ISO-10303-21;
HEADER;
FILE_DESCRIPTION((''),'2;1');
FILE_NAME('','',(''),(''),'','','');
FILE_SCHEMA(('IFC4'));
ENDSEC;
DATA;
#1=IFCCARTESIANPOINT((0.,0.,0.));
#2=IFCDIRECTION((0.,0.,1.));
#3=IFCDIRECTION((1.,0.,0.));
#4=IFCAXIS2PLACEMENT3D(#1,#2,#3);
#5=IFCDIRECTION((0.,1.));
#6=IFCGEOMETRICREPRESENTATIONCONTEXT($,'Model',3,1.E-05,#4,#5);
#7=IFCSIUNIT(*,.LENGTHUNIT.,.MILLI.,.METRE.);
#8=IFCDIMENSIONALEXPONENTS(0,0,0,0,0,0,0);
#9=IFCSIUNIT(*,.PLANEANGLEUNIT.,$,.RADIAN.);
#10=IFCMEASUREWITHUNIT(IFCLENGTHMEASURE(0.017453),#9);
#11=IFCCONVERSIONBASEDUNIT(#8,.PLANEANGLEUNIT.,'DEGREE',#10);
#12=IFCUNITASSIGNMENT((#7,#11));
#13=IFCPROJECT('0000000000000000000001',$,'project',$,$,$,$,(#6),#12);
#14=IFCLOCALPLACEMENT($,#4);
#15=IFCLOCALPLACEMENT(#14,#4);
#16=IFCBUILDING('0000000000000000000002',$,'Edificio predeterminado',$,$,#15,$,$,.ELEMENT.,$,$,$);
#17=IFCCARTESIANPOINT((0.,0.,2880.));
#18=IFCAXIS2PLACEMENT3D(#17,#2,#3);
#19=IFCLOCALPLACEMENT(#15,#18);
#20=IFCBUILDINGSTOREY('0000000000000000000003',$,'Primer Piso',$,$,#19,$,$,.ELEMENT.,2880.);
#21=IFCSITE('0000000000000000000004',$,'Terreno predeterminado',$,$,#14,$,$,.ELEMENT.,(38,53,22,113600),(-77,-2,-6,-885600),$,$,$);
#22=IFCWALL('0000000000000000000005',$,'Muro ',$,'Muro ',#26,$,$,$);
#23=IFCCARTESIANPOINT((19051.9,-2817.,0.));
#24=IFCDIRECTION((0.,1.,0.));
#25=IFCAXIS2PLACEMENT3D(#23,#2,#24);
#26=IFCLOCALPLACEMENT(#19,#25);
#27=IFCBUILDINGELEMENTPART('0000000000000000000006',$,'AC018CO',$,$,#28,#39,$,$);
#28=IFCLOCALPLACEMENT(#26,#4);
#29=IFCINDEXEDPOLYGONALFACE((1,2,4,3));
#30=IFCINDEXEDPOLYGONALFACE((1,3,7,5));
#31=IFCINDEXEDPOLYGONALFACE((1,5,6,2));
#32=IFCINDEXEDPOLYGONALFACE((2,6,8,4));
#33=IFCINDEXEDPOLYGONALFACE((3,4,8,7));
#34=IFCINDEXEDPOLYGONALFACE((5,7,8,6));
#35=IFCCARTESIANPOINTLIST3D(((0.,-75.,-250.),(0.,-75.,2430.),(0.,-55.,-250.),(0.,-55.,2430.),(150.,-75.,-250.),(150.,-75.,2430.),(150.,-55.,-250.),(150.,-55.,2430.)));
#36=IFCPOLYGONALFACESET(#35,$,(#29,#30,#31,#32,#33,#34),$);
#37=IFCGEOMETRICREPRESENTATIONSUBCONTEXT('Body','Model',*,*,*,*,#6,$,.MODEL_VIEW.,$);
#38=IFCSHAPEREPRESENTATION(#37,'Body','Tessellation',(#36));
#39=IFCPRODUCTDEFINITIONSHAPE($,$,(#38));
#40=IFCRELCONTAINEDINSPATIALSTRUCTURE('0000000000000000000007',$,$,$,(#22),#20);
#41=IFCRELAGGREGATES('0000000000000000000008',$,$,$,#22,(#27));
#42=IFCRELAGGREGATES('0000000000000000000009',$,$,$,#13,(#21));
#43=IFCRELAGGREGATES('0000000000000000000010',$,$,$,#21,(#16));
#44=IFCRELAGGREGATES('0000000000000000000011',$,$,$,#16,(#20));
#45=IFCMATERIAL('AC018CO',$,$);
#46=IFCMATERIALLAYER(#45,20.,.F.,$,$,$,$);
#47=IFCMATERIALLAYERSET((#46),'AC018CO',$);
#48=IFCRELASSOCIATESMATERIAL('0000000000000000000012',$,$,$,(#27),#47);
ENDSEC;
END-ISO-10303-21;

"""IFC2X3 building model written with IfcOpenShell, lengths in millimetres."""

from ifc_helpers import new_model, entity, si_unit, converted_unit, direction, frame, origin_with_axes, place, context, subcontext, project, spatial, polyline, outline, extrude, clip, bounded_halfspace, material, layer, layer_set, layer_usage, element, aggregate, save


model = new_model("IFC2X3")

# Units and contexts
model_context = context("Model", 3, precision=1e-05, world=origin_with_axes(), true_north=direction((0.0, 1.0)))
body_context = subcontext(model_context, "Body", "Model", "MODEL_VIEW")
ifc_project = project(units=[si_unit("LENGTHUNIT", "METRE", prefix="MILLI"), converted_unit("PLANEANGLEUNIT", "DEGREE", entity("IfcLengthMeasure", 0.017453), si_unit("PLANEANGLEUNIT", "RADIAN"), dimensions=[0, 0, 0, 0, 0, 0, 0])], contexts=[model_context])

# Site, building, storey
site_placement = place(None, origin_with_axes())
site = spatial("IfcSite", under=ifc_project, at=site_placement, Name="Terreno predeterminado", CompositionType="ELEMENT", RefLatitude=(38, 53, 22, 113600), RefLongitude=(-77, -2, -6, -885600))
building_placement = place(site_placement, origin_with_axes())
building = spatial("IfcBuilding", under=site, at=building_placement, Name="Edificio predeterminado", CompositionType="ELEMENT")
storey_placement = place(building_placement, frame((0.0, 0.0, 2880.0), z_axis=(0.0, 0.0, 1.0), x_axis=(1.0, 0.0, 0.0)))
storey = spatial("IfcBuildingStorey", under=building, at=storey_placement, Name="Primer Piso", CompositionType="ELEMENT", Elevation=2880.0)

# Wall, building element part
wall_1_placement = place(storey_placement, frame((19051.9, -2817.0, 0.0), z_axis=(0.0, 0.0, 1.0), x_axis=(0.0, 1.0, 0.0)))
wall_1 = element("IfcWall", 1, at=wall_1_placement, inside=storey, Name="Muro ", ObjectType="Muro ")
ifc_material_1 = material(Name="AC018CO")
ifc_layer_1 = layer(ifc_material_1, 20.0, ventilated=False)
ifc_layer_set_1 = layer_set([ifc_layer_1], Name="AC018CO")
ifc_layer_usage_1 = layer_usage(ifc_layer_set_1, "AXIS2", "NEGATIVE", 55.0)
building_element_part_1_placement = place(wall_1_placement, origin_with_axes())
building_element_part_1 = element("IfcBuildingElementPart", 2, at=building_element_part_1_placement, material=ifc_layer_usage_1, Name="AC018CO", context=body_context, shape_type="Clipping", body=[
    clip(clip(extrude(outline(polyline([(150.0, -55.0), (150.0, -75.0), (0.0, -75.0), (0.0, -55.0), (150.0, -55.0)])), frame((0.0, 0.0, -250.0), z_axis=(0.0, 0.0, 1.0), x_axis=(1.0, 0.0, 0.0)), (0.0, 0.0, 1.0), 2680.0), bounded_halfspace(frame((0.0, 0.0, -250.0), z_axis=(0.0, 0.0, 1.0), x_axis=(1.0, 0.0, 0.0)), True, origin_with_axes(), polyline([(-150.0, -150.0), (375.0, -150.0), (375.0, 150.0), (-150.0, 150.0), (-150.0, -150.0)]))), bounded_halfspace(frame((0.0, 0.0, 2430.0), z_axis=(0.0, 0.0, 1.0), x_axis=(1.0, 0.0, 0.0)), False, origin_with_axes(), polyline([(-150.0, -150.0), (375.0, -150.0), (375.0, 150.0), (-150.0, 150.0), (-150.0, -150.0)]))),
])
aggregate(wall_1, [building_element_part_1])

save(model, "model.ifc")
